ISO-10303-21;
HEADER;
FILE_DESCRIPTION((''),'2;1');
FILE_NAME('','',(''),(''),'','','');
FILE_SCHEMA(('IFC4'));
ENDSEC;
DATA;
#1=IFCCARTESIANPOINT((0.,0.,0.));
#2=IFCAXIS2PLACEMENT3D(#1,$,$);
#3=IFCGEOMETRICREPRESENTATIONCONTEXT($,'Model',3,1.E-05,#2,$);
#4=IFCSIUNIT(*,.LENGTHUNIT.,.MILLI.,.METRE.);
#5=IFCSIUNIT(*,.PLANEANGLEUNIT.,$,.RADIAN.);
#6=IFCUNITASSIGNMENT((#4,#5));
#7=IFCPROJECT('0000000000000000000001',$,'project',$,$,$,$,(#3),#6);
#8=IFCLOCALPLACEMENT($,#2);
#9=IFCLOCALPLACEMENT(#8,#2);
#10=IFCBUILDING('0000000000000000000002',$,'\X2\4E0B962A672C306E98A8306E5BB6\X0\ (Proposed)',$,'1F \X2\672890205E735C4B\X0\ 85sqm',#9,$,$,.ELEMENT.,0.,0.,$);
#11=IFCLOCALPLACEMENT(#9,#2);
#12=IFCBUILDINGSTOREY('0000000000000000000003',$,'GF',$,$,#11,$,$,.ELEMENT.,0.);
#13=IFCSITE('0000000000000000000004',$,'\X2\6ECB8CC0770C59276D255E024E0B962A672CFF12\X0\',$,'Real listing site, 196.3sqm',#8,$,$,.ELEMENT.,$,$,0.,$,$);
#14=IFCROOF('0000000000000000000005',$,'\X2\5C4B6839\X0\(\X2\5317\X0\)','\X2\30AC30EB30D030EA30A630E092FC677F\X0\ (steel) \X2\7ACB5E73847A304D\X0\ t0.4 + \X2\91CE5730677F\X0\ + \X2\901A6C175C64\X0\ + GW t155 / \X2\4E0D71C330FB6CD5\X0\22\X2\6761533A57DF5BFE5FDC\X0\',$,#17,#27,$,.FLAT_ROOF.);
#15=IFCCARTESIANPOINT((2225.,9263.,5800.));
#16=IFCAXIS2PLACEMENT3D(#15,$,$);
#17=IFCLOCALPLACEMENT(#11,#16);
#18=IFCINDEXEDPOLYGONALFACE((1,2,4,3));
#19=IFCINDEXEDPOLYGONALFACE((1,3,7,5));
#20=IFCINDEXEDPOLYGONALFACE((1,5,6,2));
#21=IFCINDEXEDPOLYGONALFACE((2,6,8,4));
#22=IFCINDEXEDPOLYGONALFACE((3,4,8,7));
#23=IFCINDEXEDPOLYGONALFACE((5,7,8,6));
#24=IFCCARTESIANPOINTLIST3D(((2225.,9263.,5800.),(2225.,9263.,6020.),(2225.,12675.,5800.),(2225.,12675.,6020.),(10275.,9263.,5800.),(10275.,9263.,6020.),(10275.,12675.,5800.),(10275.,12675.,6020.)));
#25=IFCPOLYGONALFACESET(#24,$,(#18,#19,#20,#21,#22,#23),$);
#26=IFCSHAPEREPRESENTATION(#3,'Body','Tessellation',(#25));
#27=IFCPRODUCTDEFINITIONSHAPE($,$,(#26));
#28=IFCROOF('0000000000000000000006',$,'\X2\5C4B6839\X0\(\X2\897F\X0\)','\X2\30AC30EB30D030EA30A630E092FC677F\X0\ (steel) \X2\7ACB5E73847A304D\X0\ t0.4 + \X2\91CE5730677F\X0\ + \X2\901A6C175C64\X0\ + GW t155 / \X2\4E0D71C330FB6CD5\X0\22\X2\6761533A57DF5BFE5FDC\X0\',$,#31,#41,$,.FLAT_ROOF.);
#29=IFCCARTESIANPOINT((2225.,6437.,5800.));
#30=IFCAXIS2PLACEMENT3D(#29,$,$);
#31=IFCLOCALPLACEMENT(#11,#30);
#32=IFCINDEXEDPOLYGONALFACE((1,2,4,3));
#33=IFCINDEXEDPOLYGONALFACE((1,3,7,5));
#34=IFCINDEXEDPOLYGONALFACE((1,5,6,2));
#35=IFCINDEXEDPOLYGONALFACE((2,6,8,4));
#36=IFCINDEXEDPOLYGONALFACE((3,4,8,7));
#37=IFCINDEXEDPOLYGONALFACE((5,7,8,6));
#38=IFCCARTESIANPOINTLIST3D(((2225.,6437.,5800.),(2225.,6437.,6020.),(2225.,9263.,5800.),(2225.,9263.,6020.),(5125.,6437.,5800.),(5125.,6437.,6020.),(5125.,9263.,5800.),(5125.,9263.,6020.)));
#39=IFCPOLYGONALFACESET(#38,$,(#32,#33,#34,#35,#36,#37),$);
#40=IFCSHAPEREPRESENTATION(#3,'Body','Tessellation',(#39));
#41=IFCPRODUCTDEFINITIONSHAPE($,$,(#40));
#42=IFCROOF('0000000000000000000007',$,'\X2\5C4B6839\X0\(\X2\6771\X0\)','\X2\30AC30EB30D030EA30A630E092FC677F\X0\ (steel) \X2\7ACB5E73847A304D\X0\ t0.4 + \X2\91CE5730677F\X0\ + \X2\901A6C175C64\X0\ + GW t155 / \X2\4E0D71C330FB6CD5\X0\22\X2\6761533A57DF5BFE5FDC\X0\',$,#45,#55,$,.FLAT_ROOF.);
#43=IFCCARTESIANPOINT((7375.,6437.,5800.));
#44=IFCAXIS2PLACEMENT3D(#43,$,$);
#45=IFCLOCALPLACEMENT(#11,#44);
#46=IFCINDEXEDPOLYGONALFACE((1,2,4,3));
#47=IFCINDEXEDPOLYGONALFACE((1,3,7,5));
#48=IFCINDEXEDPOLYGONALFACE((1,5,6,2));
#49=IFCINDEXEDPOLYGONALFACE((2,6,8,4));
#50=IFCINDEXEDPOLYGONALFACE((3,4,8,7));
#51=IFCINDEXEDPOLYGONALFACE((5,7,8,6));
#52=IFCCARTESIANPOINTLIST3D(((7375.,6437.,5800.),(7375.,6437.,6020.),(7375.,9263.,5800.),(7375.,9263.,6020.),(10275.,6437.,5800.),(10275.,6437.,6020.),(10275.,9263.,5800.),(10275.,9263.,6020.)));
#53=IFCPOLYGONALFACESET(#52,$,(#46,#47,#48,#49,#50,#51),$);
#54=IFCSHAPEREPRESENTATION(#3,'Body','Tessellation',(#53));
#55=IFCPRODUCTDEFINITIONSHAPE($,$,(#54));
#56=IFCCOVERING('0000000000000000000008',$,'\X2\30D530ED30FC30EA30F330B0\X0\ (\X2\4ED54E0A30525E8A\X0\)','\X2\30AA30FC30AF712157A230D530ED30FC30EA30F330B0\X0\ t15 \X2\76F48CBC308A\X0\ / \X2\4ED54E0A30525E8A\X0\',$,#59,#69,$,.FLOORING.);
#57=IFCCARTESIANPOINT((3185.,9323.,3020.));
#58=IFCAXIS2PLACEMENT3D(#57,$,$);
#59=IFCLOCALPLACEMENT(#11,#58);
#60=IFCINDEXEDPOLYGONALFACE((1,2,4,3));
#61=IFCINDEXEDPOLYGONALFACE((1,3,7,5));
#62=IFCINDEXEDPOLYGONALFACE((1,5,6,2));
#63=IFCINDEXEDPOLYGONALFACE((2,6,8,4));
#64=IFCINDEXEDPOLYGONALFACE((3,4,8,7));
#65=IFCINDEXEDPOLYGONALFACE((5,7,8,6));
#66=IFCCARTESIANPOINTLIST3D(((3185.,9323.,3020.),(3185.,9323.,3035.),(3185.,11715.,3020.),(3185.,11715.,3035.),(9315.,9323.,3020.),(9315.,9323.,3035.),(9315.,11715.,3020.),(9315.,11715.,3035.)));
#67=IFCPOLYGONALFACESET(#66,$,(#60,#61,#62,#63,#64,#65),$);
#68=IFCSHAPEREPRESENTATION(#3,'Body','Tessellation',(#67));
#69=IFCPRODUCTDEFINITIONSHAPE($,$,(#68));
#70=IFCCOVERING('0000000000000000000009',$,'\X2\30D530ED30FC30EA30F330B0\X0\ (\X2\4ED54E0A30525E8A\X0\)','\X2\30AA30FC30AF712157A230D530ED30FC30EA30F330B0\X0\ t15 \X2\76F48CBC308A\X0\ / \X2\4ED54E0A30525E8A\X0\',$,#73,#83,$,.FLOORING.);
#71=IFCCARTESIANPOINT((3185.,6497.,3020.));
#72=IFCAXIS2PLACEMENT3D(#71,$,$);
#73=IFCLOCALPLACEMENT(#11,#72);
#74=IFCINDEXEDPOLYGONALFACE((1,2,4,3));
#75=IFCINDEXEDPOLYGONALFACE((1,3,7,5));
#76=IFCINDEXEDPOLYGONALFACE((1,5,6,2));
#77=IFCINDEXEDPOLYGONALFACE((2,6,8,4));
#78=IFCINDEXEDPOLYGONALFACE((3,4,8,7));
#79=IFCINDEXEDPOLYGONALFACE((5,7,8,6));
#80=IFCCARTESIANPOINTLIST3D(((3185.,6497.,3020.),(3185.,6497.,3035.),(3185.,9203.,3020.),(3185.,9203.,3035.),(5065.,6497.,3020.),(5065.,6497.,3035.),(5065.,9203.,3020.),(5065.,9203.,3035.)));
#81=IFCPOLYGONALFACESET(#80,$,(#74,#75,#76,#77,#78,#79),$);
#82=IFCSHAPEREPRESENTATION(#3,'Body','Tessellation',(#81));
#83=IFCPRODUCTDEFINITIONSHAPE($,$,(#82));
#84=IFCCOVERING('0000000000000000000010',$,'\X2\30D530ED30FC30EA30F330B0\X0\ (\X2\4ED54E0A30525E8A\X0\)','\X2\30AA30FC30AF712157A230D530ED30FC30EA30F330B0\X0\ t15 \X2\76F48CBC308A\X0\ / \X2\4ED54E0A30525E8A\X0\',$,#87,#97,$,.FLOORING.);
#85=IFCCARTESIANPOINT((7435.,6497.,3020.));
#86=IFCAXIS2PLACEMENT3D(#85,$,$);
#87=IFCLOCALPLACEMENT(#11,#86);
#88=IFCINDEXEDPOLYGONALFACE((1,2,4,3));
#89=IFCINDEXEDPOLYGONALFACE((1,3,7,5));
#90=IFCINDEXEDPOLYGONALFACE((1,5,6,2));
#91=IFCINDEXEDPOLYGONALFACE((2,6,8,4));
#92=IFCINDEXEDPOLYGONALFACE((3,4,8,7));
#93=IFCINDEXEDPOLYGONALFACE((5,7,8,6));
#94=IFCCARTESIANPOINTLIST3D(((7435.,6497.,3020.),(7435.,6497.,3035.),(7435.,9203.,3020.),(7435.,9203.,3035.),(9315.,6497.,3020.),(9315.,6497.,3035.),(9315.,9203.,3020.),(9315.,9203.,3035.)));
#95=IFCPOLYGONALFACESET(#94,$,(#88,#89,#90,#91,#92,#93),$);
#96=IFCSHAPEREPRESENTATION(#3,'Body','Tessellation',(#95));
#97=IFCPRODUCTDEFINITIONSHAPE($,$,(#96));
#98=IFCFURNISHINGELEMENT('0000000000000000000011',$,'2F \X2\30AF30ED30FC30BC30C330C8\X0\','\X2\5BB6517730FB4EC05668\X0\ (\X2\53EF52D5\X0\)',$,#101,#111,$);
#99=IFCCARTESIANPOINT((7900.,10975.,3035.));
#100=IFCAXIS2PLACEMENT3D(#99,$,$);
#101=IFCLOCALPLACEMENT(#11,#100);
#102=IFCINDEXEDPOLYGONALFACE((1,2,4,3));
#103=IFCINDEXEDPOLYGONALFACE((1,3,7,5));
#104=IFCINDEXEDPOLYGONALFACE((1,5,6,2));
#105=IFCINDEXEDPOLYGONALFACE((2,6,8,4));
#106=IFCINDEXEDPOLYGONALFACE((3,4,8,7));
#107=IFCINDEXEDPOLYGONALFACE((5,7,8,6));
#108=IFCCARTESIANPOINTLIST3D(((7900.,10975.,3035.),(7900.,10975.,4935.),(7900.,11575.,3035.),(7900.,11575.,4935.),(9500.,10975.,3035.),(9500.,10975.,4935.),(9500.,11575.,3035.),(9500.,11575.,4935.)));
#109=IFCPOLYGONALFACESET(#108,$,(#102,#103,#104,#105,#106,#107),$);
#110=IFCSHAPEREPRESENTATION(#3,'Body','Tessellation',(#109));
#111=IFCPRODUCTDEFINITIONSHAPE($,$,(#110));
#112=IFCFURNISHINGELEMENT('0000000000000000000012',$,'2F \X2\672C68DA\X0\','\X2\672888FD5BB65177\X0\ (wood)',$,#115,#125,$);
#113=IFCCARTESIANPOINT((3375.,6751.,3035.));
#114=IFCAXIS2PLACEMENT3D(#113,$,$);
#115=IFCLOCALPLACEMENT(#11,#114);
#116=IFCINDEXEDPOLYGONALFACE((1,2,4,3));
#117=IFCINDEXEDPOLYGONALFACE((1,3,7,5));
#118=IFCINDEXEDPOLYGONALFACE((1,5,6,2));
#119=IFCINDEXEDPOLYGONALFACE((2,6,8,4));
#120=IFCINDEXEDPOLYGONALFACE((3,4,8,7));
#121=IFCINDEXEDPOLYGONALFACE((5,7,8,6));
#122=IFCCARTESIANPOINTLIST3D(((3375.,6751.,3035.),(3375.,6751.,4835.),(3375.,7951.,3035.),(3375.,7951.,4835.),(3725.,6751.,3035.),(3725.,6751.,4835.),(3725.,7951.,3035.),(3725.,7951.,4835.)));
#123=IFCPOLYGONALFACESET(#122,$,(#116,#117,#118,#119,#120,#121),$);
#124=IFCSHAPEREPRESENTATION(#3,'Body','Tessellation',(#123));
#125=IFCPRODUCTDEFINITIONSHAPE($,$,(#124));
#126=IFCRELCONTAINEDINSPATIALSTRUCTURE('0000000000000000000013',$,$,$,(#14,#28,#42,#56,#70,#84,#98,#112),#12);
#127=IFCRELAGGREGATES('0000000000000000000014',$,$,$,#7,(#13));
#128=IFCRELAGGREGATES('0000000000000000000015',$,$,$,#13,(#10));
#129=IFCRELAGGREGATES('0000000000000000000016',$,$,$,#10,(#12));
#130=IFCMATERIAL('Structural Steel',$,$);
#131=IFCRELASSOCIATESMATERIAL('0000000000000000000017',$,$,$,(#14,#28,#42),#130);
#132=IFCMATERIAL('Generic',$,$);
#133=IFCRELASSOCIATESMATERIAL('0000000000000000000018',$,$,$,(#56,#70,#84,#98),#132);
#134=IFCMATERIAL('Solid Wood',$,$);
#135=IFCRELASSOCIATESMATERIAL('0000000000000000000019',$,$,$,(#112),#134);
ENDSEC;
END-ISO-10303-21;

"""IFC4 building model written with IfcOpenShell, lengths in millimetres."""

from ifc_helpers import new_model, si_unit, frame, frame_2d, origin, place, context, project, spatial, rectangle, extrude, material, element, save


model = new_model("IFC4")

# Units and contexts
model_context = context("Model", 3, precision=1e-05, world=origin())
ifc_project = project(units=[si_unit("LENGTHUNIT", "METRE", prefix="MILLI"), si_unit("PLANEANGLEUNIT", "RADIAN")], contexts=[model_context])

# Site, building, storey
site_placement = place(None, origin())
site = spatial("IfcSite", under=ifc_project, at=site_placement, Name="滋賀県大津市下阪本２", ObjectType="Real listing site, 196.3sqm", CompositionType="ELEMENT", RefElevation=0.0)
building_placement = place(site_placement, origin())
building = spatial("IfcBuilding", under=site, at=building_placement, Name="下阪本の風の家 (Proposed)", ObjectType="1F 木造平屋 85sqm", CompositionType="ELEMENT", ElevationOfRefHeight=0.0, ElevationOfTerrain=0.0)
storey_placement = place(building_placement, origin())
storey = spatial("IfcBuildingStorey", under=building, at=storey_placement, Name="GF", CompositionType="ELEMENT", Elevation=0.0)

# Shared definitions
ifc_material_1 = material(Name="Solid Wood")

# Shared definitions
ifc_material_2 = material(Name="Generic")

# Roofs
ifc_material_3 = material(Name="Structural Steel")
for number, where, name in (
    (1, (2225.0, 9263.0, 5800.0), "屋根(北)"),
):
    element("IfcRoof", number, at=place(storey_placement, frame(where)), inside=storey, material=ifc_material_3, Name=name, Description="ガルバリウム鋼板 (steel) 立平葺き t0.4 + 野地板 + 通気層 + GW t155 / 不燃・法22条区域対応", PredefinedType="FLAT_ROOF", context=model_context, shape_type="SweptSolid", body=[
        extrude(rectangle(XDim=8050.0, YDim=3412.0, at=frame_2d((4025.0, 1706.0))), frame((2225.0, 9263.0, 5800.0)), (0.0, 0.0, 1.0), 220.0),
    ])
roof_1_placement = place(storey_placement, frame((2225.0, 6437.0, 5800.0)))
element("IfcRoof", 2, at=roof_1_placement, inside=storey, material=ifc_material_3, Name="屋根(西)", Description="ガルバリウム鋼板 (steel) 立平葺き t0.4 + 野地板 + 通気層 + GW t155 / 不燃・法22条区域対応", PredefinedType="FLAT_ROOF", context=model_context, shape_type="SweptSolid", body=[
    extrude(rectangle(XDim=2900.0, YDim=2826.0, at=frame_2d((1450.0, 1413.0))), frame((2225.0, 6437.0, 5800.0)), (0.0, 0.0, 1.0), 220.0),
])
roof_2_placement = place(storey_placement, frame((7375.0, 6437.0, 5800.0)))
element("IfcRoof", 3, at=roof_2_placement, inside=storey, material=ifc_material_3, Name="屋根(東)", Description="ガルバリウム鋼板 (steel) 立平葺き t0.4 + 野地板 + 通気層 + GW t155 / 不燃・法22条区域対応", PredefinedType="FLAT_ROOF", context=model_context, shape_type="SweptSolid", body=[
    extrude(rectangle(XDim=2900.0, YDim=2826.0, at=frame_2d((1450.0, 1413.0))), frame((7375.0, 6437.0, 5800.0)), (0.0, 0.0, 1.0), 220.0),
])

# Coverings
covering_1_placement = place(storey_placement, frame((3185.0, 9323.0, 3020.0)))
element("IfcCovering", 4, at=covering_1_placement, inside=storey, material=ifc_material_2, Name="フローリング (仕上げ床)", Description="オーク無垢フローリング t15 直貼り / 仕上げ床", PredefinedType="FLOORING", context=model_context, shape_type="SweptSolid", body=[
    extrude(rectangle(XDim=6130.0, YDim=2392.0, at=frame_2d((3065.0, 1196.0))), frame((3185.0, 9323.0, 3020.0)), (0.0, 0.0, 1.0), 15.0),
])
covering_2_placement = place(storey_placement, frame((3185.0, 6497.0, 3020.0)))
element("IfcCovering", 5, at=covering_2_placement, inside=storey, material=ifc_material_2, Name="フローリング (仕上げ床)", Description="オーク無垢フローリング t15 直貼り / 仕上げ床", PredefinedType="FLOORING", context=model_context, shape_type="SweptSolid", body=[
    extrude(rectangle(XDim=1880.0, YDim=2706.0, at=frame_2d((940.0, 1353.0))), frame((3185.0, 6497.0, 3020.0)), (0.0, 0.0, 1.0), 15.0),
])
covering_3_placement = place(storey_placement, frame((7435.0, 6497.0, 3020.0)))
element("IfcCovering", 6, at=covering_3_placement, inside=storey, material=ifc_material_2, Name="フローリング (仕上げ床)", Description="オーク無垢フローリング t15 直貼り / 仕上げ床", PredefinedType="FLOORING", context=model_context, shape_type="SweptSolid", body=[
    extrude(rectangle(XDim=1880.0, YDim=2706.0, at=frame_2d((940.0, 1353.0))), frame((7435.0, 6497.0, 3020.0)), (0.0, 0.0, 1.0), 15.0),
])

# Furnishing elements
furnishing_1_placement = place(storey_placement, frame((7900.0, 10975.0, 3035.0)))
element("IfcFurnishingElement", 7, at=furnishing_1_placement, inside=storey, material=ifc_material_2, Name="2F クローゼット", Description="家具・什器 (可動)", context=model_context, shape_type="SweptSolid", body=[
    extrude(rectangle(XDim=1600.0, YDim=600.0, at=frame_2d((800.0, 300.0))), frame((7900.0, 10975.0, 3035.0)), (0.0, 0.0, 1.0), 1900.0),
])
furnishing_2_placement = place(storey_placement, frame((3375.0, 6751.0, 3035.0)))
element("IfcFurnishingElement", 8, at=furnishing_2_placement, inside=storey, material=ifc_material_1, Name="2F 本棚", Description="木製家具 (wood)", context=model_context, shape_type="SweptSolid", body=[
    extrude(rectangle(XDim=350.0, YDim=1200.0, at=frame_2d((175.0, 600.0))), frame((3375.0, 6751.0, 3035.0)), (0.0, 0.0, 1.0), 1800.0),
])

save(model, "model.ifc")
